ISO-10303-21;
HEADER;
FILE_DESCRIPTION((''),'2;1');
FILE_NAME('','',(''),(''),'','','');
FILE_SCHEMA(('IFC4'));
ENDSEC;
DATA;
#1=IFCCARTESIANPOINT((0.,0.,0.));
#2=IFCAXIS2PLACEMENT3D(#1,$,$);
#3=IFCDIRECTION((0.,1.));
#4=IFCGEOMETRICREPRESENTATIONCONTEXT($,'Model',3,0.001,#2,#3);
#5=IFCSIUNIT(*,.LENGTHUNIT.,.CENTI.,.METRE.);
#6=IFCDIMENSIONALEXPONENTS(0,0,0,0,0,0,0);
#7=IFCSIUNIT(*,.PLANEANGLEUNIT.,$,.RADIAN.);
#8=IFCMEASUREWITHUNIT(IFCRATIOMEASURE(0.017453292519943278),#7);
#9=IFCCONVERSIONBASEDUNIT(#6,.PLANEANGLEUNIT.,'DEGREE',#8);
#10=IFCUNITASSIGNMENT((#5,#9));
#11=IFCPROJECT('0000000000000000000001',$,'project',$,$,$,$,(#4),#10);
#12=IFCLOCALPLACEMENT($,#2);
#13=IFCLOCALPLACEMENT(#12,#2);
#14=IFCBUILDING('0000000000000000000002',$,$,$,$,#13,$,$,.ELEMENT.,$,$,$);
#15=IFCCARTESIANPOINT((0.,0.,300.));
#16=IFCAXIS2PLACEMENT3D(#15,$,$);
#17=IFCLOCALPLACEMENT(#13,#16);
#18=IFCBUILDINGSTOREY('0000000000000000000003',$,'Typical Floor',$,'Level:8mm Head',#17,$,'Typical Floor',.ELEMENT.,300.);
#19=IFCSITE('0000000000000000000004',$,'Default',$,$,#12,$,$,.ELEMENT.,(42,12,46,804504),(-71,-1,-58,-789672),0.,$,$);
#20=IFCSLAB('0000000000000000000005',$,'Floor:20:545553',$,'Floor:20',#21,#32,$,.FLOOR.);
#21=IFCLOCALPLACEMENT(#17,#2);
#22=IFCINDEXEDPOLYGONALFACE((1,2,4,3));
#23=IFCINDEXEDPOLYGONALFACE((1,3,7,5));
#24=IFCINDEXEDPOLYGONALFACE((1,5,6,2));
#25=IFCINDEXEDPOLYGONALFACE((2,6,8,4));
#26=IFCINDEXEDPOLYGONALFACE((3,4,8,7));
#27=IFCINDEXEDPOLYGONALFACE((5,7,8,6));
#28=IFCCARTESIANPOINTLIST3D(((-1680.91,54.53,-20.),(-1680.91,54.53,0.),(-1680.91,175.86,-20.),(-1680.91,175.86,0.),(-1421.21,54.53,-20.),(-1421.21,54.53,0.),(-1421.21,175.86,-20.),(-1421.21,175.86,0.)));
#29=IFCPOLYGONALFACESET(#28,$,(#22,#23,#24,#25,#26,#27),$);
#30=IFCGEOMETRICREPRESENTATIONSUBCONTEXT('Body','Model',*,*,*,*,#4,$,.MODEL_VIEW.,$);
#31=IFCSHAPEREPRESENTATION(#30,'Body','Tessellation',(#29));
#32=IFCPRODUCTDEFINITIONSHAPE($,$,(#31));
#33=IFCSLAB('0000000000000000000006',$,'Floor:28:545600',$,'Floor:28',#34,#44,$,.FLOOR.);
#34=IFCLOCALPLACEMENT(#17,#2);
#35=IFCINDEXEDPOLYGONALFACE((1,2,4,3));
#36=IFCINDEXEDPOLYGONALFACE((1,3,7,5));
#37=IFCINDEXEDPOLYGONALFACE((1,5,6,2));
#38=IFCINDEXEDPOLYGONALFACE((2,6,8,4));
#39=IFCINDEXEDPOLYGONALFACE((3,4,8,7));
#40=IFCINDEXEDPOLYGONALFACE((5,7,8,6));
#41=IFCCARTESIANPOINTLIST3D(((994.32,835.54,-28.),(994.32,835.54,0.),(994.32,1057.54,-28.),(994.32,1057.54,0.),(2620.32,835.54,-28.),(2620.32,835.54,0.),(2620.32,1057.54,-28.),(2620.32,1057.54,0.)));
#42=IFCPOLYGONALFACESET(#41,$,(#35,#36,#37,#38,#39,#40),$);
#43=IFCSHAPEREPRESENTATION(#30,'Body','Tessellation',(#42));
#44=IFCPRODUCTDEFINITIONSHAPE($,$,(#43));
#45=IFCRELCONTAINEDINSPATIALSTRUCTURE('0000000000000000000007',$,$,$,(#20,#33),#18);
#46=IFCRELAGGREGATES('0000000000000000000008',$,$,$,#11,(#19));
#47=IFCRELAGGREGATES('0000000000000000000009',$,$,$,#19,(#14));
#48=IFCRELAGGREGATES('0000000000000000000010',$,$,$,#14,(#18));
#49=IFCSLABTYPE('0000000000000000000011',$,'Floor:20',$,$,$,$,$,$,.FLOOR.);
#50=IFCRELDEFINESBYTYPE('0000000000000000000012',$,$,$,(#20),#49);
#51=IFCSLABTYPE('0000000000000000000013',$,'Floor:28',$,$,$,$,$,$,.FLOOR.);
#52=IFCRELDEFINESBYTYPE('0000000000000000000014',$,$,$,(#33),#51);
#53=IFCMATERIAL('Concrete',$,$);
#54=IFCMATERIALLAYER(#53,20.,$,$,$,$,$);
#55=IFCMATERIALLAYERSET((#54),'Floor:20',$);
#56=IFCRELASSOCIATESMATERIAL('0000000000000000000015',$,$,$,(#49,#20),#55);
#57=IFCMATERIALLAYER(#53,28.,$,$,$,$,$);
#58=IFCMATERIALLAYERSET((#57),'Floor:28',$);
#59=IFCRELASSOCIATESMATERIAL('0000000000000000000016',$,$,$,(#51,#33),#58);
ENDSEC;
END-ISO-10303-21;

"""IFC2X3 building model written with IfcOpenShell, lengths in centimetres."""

from ifc_helpers import new_model, entity, si_unit, converted_unit, direction, frame, frame_2d, origin, place, context, subcontext, project, spatial, rectangle, extrude, material, layer, layer_set, layer_usage, type_object, element, save


model = new_model("IFC2X3")

# Units and contexts
model_context = context("Model", 3, precision=0.001, world=origin(), true_north=direction((0.0, 1.0)))
body_context = subcontext(model_context, "Body", "Model", "MODEL_VIEW")
ifc_project = project(units=[si_unit("LENGTHUNIT", "METRE", prefix="CENTI"), converted_unit("PLANEANGLEUNIT", "DEGREE", entity("IfcRatioMeasure", 0.017453292519943278), si_unit("PLANEANGLEUNIT", "RADIAN"), dimensions=[0, 0, 0, 0, 0, 0, 0])], contexts=[model_context])

# Site, building, storey
site_placement = place(None, origin())
site = spatial("IfcSite", under=ifc_project, at=site_placement, Name="Default", CompositionType="ELEMENT", RefLatitude=(42, 12, 46, 804504), RefLongitude=(-71, -1, -58, -789672), RefElevation=0.0)
building_placement = place(site_placement, origin())
building = spatial("IfcBuilding", under=site, at=building_placement, CompositionType="ELEMENT")
storey_placement = place(building_placement, frame((0.0, 0.0, 300.0)))
storey = spatial("IfcBuildingStorey", under=building, at=storey_placement, Name="Typical Floor", ObjectType="Level:8mm Head", LongName="Typical Floor", CompositionType="ELEMENT", Elevation=300.0)

# Shared definitions
ifc_material = material(Name="Concrete")

# Slabs
ifc_layer_1 = layer(ifc_material, 20.0)
ifc_layer_set_1 = layer_set([ifc_layer_1], Name="Floor:20")
ifc_layer_usage_1 = layer_usage(ifc_layer_set_1, "AXIS3", "POSITIVE", 0.0)
slab_type_1 = type_object("IfcSlabType", Name="Floor:20", PredefinedType="FLOOR", material=ifc_layer_set_1)
slab_1_placement = place(storey_placement, origin())
element("IfcSlab", 1, at=slab_1_placement, inside=storey, type_object=slab_type_1, material=ifc_layer_usage_1, Name="Floor:20:545553", ObjectType="Floor:20", PredefinedType="FLOOR", context=body_context, shape_type="SweptSolid", body=[
    extrude(rectangle(XDim=121.33, YDim=259.7, at=frame_2d((0.0, 0.0), x_axis=(1.0, 0.0))), frame((-1551.06, 115.2, 0.0), z_axis=(0.0, 0.0, -1.0), x_axis=(0.0, 1.0, 0.0)), (0.0, 0.0, 1.0), 20.0),
])
ifc_layer_2 = layer(ifc_material, 28.0)
ifc_layer_set_2 = layer_set([ifc_layer_2], Name="Floor:28")
ifc_layer_usage_2 = layer_usage(ifc_layer_set_2, "AXIS3", "POSITIVE", 0.0)
slab_type_2 = type_object("IfcSlabType", Name="Floor:28", PredefinedType="FLOOR", material=ifc_layer_set_2)
slab_2_placement = place(storey_placement, origin())
element("IfcSlab", 2, at=slab_2_placement, inside=storey, type_object=slab_type_2, material=ifc_layer_usage_2, Name="Floor:28:545600", ObjectType="Floor:28", PredefinedType="FLOOR", context=body_context, shape_type="SweptSolid", body=[
    extrude(rectangle(XDim=222.0, YDim=1626.0, at=frame_2d((0.0, 0.0), x_axis=(1.0, 0.0))), frame((1807.32, 946.54, 0.0), z_axis=(0.0, 0.0, -1.0), x_axis=(0.0, 1.0, 0.0)), (0.0, 0.0, 1.0), 28.0),
])

save(model, "model.ifc")
